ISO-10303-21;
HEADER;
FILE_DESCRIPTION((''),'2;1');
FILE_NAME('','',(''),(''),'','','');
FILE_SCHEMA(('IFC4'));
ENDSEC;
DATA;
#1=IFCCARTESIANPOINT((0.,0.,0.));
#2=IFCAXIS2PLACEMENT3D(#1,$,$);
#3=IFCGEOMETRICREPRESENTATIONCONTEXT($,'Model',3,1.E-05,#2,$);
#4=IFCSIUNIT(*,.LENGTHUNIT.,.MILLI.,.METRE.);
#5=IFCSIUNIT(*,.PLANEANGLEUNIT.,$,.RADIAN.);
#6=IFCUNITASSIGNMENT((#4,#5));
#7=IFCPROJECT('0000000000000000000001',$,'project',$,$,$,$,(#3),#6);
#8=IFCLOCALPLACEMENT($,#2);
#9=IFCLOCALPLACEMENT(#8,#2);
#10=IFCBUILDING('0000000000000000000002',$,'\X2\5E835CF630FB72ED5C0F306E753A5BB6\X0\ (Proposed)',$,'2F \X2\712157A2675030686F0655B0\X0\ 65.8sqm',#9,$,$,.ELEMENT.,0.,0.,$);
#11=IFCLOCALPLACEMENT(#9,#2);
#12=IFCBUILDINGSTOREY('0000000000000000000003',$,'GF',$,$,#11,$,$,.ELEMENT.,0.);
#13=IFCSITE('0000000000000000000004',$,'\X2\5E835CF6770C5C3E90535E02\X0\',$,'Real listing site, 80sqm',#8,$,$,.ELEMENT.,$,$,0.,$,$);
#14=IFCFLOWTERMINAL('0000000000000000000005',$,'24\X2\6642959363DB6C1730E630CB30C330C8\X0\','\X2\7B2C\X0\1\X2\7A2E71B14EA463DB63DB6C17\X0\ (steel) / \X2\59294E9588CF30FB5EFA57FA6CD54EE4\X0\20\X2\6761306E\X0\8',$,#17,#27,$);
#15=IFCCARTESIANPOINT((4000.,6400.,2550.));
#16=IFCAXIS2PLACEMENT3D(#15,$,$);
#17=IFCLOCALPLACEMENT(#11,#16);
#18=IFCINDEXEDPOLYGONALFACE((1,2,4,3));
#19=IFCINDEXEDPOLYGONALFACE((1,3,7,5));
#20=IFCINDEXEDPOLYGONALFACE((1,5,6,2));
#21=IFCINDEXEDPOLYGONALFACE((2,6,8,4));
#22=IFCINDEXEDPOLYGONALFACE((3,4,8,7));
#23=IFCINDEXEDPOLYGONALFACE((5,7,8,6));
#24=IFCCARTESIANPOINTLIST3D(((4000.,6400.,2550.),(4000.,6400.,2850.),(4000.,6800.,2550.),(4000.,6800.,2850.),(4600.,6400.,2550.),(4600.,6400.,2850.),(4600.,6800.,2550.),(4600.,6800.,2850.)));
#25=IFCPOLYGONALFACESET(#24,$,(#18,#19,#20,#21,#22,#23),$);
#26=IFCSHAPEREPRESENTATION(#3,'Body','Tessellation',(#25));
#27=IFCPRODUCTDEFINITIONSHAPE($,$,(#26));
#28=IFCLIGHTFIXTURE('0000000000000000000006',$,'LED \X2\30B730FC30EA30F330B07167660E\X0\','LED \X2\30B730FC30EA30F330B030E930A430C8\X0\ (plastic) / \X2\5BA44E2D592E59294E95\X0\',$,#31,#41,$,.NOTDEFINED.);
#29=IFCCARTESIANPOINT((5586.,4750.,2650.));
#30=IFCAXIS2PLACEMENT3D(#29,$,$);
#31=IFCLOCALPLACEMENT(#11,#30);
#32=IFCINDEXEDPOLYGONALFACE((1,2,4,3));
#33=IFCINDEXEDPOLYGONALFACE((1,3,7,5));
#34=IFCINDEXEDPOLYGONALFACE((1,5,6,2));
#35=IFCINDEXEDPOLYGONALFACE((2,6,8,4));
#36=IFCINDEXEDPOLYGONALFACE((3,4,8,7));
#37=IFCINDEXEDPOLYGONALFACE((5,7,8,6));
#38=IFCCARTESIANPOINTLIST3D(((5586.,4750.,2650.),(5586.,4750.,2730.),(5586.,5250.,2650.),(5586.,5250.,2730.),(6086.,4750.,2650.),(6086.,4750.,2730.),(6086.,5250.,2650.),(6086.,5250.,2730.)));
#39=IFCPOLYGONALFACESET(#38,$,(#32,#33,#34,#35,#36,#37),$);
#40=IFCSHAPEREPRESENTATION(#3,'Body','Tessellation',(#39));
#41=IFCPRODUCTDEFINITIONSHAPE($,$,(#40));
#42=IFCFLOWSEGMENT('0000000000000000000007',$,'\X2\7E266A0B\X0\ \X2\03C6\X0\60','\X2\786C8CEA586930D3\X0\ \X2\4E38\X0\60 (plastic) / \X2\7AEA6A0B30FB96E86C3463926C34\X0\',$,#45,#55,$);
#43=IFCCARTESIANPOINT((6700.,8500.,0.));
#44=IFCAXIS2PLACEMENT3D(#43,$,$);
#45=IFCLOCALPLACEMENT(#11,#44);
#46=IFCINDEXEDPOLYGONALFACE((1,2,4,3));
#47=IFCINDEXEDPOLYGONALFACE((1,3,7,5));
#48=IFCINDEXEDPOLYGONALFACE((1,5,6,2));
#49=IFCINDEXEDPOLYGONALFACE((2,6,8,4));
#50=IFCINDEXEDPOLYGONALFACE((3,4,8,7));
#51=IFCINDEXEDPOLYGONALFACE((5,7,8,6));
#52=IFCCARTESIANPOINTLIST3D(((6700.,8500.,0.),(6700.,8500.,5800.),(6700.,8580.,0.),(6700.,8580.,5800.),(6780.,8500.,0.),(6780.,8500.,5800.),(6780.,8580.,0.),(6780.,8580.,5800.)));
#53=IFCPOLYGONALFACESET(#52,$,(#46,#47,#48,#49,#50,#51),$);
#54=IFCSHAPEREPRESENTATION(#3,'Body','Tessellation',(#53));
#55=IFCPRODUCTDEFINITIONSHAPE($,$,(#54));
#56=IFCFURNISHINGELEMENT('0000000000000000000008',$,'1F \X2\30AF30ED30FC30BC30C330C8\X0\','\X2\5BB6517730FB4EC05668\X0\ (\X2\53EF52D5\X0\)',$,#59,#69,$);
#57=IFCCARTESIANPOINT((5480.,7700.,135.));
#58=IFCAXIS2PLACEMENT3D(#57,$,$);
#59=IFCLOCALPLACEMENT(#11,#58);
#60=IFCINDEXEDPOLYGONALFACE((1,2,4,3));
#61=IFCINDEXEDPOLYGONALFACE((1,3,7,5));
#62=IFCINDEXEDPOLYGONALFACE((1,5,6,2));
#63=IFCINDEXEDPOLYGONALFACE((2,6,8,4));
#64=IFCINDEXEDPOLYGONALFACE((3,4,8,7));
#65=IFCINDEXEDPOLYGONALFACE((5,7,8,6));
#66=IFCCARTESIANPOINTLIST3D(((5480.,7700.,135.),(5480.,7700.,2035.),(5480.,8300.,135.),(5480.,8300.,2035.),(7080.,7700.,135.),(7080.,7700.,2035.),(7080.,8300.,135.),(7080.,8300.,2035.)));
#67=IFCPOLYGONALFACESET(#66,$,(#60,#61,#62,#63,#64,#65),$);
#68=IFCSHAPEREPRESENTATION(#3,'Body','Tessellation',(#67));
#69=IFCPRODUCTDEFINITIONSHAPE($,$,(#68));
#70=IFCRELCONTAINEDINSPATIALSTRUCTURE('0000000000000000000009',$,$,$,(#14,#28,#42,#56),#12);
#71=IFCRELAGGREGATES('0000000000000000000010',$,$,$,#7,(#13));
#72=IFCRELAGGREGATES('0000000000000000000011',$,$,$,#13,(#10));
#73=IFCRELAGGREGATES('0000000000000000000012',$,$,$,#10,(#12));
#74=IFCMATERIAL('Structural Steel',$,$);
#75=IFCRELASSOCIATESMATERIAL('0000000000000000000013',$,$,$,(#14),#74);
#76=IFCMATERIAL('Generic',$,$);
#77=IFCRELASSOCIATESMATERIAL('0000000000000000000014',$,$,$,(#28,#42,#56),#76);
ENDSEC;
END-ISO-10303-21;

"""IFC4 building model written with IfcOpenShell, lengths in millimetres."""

from ifc_helpers import new_model, si_unit, frame, frame_2d, origin, place, context, project, spatial, rectangle, extrude, material, element, save


model = new_model("IFC4")

# Units and contexts
model_context = context("Model", 3, precision=1e-05, world=origin())
ifc_project = project(units=[si_unit("LENGTHUNIT", "METRE", prefix="MILLI"), si_unit("PLANEANGLEUNIT", "RADIAN")], contexts=[model_context])

# Site, building, storey
site_placement = place(None, origin())
site = spatial("IfcSite", under=ifc_project, at=site_placement, Name="広島県尾道市", ObjectType="Real listing site, 80sqm", CompositionType="ELEMENT", RefElevation=0.0)
building_placement = place(site_placement, origin())
building = spatial("IfcBuilding", under=site, at=building_placement, Name="広島・狭小の町家 (Proposed)", ObjectType="2F 無垢材と漆喰 65.8sqm", CompositionType="ELEMENT", ElevationOfRefHeight=0.0, ElevationOfTerrain=0.0)
storey_placement = place(building_placement, origin())
storey = spatial("IfcBuildingStorey", under=building, at=storey_placement, Name="GF", CompositionType="ELEMENT", Elevation=0.0)

# Shared definitions
ifc_material_1 = material(Name="Generic")

# Flow terminal
ifc_material_2 = material(Name="Structural Steel")
flow_terminal_placement = place(storey_placement, frame((4000.0, 6400.0, 2550.0)))
element("IfcFlowTerminal", 1, at=flow_terminal_placement, inside=storey, material=ifc_material_2, Name="24時間換気ユニット", Description="第1種熱交換換気 (steel) / 天井裏・建基法令20条の8", context=model_context, shape_type="SweptSolid", body=[
    extrude(rectangle(XDim=600.0, YDim=400.0, at=frame_2d((300.0, 200.0))), frame((4000.0, 6400.0, 2550.0)), (0.0, 0.0, 1.0), 300.0),
])

# Light fixture
light_fixture_placement = place(storey_placement, frame((5586.0, 4750.0, 2650.0)))
element("IfcLightFixture", 2, at=light_fixture_placement, inside=storey, material=ifc_material_1, Name="LED シーリング照明", Description="LED シーリングライト (plastic) / 室中央天井", PredefinedType="NOTDEFINED", context=model_context, shape_type="SweptSolid", body=[
    extrude(rectangle(XDim=500.0, YDim=500.0, at=frame_2d((250.0, 250.0))), frame((5586.0, 4750.0, 2650.0)), (0.0, 0.0, 1.0), 80.0),
])

# Flow segment
flow_segment_placement = place(storey_placement, frame((6700.0, 8500.0, 0.0)))
element("IfcFlowSegment", 3, at=flow_segment_placement, inside=storey, material=ifc_material_1, Name="縦樋 φ60", Description="硬質塩ビ 丸60 (plastic) / 竪樋・雨水排水", context=model_context, shape_type="SweptSolid", body=[
    extrude(rectangle(XDim=80.0, YDim=80.0, at=frame_2d((40.0, 40.0))), frame((6700.0, 8500.0, 0.0)), (0.0, 0.0, 1.0), 5800.0),
])

# Furnishing element
furnishing_placement = place(storey_placement, frame((5480.0, 7700.0, 135.0)))
element("IfcFurnishingElement", 4, at=furnishing_placement, inside=storey, material=ifc_material_1, Name="1F クローゼット", Description="家具・什器 (可動)", context=model_context, shape_type="SweptSolid", body=[
    extrude(rectangle(XDim=1600.0, YDim=600.0, at=frame_2d((800.0, 300.0))), frame((5480.0, 7700.0, 135.0)), (0.0, 0.0, 1.0), 1900.0),
])

save(model, "model.ifc")
